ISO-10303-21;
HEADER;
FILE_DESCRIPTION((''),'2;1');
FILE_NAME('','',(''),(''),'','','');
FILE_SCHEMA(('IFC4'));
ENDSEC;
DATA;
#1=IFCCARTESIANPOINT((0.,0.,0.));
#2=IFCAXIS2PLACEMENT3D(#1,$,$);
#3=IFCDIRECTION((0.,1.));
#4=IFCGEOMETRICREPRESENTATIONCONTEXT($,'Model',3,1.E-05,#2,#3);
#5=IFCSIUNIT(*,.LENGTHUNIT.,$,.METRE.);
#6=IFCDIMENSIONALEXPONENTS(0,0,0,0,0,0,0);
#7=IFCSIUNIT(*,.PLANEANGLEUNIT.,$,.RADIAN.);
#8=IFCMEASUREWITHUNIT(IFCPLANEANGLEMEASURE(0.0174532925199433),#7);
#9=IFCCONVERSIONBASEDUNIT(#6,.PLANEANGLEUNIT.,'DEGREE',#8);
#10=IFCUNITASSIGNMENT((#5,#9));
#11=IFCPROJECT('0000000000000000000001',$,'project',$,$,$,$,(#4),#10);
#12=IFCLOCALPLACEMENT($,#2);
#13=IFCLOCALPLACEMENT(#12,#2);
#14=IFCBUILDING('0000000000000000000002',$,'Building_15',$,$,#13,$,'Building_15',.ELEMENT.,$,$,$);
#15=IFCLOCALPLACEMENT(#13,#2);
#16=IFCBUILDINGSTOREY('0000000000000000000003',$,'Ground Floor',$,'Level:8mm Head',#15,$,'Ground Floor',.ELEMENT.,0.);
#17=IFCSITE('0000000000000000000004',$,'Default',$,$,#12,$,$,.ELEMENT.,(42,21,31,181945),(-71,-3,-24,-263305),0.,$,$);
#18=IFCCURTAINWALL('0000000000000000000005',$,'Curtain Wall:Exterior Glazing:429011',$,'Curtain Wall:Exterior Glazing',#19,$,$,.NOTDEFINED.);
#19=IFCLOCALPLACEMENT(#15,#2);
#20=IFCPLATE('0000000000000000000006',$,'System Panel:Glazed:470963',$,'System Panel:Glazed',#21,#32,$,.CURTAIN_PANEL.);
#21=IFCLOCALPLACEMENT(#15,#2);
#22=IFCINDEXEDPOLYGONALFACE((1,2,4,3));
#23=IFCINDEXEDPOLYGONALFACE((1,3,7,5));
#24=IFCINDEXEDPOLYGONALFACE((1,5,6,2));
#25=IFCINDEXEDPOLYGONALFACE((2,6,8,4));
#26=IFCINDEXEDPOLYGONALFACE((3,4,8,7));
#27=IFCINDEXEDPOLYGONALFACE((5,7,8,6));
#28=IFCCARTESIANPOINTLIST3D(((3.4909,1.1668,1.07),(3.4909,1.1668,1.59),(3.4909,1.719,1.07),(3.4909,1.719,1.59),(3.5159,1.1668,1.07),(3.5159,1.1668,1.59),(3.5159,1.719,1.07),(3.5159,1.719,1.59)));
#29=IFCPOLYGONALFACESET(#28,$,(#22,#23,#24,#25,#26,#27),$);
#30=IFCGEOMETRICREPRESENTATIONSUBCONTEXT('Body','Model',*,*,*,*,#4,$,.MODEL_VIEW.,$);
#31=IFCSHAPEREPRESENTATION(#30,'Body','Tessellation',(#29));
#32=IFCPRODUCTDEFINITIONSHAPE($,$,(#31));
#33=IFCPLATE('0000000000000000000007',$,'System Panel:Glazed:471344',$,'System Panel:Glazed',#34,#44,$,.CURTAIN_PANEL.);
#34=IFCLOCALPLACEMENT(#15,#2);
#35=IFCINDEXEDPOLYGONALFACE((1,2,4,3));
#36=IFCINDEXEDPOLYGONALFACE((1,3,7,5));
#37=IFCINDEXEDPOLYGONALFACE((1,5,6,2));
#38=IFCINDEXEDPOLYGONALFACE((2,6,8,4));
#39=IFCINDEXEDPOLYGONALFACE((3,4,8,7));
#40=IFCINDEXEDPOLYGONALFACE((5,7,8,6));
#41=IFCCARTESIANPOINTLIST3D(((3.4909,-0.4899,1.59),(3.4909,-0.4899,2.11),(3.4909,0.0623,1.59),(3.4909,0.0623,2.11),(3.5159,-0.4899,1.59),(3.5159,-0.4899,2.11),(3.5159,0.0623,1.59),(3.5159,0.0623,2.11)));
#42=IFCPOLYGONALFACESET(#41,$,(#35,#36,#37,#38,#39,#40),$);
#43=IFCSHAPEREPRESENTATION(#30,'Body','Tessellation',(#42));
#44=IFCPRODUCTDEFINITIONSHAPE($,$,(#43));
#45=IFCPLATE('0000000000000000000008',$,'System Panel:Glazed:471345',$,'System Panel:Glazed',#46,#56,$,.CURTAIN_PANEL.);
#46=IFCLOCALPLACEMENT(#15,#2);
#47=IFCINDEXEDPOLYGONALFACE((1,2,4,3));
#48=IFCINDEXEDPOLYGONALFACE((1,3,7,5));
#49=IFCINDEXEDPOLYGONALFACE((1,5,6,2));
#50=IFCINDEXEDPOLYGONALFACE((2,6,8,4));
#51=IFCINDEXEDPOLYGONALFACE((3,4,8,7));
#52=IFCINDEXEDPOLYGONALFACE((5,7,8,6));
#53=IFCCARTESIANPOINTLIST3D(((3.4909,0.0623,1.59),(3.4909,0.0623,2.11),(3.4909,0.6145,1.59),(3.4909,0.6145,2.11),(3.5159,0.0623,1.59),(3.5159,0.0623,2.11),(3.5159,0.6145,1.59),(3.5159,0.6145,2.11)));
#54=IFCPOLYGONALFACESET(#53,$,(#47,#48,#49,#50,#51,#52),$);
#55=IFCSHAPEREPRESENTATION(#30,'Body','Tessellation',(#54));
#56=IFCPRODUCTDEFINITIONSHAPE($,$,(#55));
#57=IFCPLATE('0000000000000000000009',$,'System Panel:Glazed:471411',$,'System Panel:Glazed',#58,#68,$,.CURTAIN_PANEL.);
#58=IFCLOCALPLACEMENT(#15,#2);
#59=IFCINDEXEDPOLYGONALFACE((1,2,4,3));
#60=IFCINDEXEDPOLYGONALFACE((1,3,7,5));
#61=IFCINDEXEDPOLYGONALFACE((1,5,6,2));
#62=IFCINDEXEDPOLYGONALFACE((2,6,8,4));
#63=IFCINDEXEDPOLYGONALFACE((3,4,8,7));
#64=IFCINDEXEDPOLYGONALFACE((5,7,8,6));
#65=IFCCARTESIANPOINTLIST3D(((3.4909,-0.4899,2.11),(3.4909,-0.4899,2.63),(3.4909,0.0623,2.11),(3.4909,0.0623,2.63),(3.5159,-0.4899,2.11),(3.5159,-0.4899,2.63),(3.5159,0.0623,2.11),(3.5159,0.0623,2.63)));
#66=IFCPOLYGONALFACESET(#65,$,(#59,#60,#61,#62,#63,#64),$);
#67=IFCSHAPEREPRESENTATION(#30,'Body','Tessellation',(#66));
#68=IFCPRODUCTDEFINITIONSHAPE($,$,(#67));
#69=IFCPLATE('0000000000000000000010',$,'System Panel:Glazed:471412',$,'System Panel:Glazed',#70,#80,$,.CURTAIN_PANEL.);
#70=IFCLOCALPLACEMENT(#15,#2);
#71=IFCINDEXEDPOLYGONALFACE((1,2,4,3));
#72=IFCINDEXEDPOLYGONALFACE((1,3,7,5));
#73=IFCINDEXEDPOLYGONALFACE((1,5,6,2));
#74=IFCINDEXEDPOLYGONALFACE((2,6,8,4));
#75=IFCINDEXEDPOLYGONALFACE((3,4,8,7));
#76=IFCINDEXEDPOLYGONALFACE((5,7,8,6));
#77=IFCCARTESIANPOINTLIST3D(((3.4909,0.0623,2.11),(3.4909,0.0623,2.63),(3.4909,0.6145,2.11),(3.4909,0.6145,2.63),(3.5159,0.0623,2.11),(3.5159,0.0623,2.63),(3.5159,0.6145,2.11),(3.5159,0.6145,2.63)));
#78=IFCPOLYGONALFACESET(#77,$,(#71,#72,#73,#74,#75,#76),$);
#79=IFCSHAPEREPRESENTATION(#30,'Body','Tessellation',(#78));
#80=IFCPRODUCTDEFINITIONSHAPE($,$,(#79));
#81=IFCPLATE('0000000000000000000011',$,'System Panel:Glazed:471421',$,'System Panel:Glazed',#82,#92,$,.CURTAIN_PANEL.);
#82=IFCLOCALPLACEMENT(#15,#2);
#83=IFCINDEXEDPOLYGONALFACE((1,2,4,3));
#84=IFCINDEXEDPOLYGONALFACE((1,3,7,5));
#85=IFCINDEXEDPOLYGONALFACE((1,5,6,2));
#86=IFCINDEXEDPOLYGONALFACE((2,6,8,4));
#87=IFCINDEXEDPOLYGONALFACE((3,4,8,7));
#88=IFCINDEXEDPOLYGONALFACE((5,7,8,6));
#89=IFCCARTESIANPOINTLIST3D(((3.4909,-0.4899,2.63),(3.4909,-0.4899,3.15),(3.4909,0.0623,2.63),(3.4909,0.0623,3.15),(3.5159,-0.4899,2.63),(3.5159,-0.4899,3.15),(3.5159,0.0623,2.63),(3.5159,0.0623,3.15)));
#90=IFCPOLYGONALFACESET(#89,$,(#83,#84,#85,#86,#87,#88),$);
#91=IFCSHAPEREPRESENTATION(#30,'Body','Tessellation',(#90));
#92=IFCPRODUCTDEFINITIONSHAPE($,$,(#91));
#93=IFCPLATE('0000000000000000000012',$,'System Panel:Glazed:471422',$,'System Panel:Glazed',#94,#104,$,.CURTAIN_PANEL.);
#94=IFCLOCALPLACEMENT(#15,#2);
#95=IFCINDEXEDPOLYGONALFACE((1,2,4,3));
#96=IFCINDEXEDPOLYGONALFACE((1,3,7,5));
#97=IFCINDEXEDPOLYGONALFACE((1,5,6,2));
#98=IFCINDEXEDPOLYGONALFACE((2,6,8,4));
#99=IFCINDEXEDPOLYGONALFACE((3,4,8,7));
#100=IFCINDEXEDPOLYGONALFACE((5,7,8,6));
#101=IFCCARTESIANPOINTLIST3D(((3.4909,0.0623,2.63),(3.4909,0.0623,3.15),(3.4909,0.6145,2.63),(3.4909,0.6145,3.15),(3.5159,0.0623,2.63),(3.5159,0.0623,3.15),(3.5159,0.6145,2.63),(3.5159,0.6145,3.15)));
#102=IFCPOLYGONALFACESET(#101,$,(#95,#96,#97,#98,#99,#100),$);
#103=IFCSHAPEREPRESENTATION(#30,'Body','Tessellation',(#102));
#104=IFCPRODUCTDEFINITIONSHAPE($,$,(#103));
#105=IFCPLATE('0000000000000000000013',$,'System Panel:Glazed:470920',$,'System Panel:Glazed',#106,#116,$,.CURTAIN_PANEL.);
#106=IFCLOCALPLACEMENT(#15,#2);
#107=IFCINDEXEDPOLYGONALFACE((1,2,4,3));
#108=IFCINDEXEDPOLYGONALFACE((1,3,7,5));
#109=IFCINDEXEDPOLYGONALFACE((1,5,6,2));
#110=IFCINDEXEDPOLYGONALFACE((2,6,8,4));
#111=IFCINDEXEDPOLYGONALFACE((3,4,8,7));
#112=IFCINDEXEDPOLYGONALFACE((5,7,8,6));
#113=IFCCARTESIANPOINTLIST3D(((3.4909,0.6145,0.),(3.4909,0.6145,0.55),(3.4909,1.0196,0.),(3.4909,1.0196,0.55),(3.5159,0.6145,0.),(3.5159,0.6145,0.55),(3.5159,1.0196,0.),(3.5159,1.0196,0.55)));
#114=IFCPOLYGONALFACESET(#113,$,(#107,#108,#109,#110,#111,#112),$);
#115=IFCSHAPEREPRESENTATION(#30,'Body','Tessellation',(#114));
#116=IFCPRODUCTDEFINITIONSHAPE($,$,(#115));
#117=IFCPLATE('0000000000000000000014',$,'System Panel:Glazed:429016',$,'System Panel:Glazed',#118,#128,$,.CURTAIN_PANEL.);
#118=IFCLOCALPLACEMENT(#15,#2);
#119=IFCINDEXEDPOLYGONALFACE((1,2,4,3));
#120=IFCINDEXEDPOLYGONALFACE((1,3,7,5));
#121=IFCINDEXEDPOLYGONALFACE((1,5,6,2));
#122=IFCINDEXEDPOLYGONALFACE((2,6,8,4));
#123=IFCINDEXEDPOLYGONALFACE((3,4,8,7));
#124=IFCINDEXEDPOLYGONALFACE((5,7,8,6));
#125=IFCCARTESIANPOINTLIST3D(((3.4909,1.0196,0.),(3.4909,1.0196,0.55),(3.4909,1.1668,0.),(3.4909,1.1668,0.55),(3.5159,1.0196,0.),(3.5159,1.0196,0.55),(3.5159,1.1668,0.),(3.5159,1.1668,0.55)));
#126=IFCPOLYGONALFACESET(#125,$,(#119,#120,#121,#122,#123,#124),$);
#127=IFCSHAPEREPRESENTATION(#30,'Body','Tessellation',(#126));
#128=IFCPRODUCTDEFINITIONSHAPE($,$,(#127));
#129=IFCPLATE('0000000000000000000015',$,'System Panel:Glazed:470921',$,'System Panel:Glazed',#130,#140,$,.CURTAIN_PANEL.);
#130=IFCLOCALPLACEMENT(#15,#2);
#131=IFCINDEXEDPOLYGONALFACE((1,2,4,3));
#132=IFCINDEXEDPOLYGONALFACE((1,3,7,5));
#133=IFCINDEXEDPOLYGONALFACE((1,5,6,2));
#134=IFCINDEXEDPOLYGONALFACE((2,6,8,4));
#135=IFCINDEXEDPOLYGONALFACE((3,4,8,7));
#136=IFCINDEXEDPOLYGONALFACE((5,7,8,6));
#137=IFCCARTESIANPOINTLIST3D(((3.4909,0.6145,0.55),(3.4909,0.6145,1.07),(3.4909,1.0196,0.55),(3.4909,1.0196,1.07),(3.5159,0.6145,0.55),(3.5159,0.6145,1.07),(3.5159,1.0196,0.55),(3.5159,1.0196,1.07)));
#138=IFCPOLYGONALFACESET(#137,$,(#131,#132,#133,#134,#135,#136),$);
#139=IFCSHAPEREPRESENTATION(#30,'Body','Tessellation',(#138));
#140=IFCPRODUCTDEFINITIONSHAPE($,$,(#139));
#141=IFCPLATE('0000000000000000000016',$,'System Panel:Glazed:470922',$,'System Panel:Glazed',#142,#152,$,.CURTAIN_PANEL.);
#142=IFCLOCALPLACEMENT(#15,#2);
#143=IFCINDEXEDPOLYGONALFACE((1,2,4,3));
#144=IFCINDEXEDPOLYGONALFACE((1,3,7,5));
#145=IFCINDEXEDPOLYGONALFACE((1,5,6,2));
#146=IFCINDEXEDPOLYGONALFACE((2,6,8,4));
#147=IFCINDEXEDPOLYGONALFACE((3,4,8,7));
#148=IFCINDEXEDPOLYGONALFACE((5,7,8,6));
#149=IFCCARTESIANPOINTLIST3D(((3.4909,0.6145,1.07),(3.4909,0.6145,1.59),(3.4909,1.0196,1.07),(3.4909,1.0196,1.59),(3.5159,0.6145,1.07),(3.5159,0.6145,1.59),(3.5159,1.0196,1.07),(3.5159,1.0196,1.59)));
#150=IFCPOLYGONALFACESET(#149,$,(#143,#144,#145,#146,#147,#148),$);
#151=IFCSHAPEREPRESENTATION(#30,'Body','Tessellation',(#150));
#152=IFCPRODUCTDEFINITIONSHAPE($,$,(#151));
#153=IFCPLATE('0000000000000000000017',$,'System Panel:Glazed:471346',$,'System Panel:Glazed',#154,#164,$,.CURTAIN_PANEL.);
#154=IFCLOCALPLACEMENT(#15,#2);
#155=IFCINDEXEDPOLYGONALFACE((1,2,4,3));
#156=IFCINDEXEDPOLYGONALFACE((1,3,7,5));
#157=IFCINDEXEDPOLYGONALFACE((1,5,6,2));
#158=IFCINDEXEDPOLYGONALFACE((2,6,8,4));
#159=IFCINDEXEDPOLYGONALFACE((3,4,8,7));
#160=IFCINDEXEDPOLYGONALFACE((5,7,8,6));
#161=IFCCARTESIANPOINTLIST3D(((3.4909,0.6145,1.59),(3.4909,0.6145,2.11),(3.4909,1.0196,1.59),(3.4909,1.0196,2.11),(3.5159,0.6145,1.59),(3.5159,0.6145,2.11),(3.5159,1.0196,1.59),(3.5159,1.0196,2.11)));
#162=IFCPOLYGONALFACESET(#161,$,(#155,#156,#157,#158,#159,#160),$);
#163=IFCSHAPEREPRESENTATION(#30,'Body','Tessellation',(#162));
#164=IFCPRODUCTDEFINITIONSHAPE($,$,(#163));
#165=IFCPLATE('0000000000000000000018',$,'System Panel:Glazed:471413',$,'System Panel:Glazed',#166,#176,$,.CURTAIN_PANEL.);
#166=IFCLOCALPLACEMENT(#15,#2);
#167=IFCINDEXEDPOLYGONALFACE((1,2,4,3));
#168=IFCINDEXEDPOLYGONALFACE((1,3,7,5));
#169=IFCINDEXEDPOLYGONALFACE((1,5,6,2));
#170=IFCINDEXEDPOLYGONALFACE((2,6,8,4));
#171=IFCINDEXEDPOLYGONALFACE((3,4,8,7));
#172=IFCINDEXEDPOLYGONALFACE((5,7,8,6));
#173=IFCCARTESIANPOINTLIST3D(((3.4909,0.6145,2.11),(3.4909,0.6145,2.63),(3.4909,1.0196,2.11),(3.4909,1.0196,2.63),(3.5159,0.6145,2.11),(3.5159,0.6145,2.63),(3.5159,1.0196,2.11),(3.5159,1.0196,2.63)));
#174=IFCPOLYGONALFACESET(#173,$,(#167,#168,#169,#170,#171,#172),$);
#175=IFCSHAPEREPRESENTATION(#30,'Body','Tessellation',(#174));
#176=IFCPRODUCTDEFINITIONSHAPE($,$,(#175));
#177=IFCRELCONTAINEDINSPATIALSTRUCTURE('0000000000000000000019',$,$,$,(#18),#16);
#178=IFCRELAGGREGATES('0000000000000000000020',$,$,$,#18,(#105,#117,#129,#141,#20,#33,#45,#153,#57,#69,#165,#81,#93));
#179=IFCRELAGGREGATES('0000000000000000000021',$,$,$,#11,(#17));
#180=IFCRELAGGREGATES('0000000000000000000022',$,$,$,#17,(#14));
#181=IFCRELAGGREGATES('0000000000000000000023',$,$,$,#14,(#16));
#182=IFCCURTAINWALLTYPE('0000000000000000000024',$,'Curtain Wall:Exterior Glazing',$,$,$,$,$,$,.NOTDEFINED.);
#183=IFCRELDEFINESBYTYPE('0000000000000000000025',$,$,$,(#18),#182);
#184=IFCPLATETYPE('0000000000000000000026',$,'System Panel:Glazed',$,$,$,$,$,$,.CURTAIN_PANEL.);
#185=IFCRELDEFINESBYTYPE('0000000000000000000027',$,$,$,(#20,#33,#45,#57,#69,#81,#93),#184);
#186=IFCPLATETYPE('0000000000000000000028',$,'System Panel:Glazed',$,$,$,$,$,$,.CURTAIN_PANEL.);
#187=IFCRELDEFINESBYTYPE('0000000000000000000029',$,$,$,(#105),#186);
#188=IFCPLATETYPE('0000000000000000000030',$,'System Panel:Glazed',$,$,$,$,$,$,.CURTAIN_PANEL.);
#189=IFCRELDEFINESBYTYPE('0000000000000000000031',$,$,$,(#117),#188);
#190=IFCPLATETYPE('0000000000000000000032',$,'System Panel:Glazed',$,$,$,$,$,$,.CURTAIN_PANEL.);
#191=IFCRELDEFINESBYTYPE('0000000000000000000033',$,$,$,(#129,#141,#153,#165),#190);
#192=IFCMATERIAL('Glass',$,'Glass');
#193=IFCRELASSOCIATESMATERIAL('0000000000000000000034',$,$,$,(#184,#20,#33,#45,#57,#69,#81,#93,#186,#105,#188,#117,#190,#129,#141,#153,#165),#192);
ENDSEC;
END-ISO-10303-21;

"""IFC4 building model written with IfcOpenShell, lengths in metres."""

from ifc_helpers import new_model, entity, si_unit, converted_unit, direction, frame, origin, place, context, subcontext, project, spatial, indexed_curve, outline, extrude, source, transform, mapped, material, type_object, type_shapes, element, aggregate, save


model = new_model("IFC4")

# Units and contexts
model_context = context("Model", 3, precision=1e-05, world=origin(), true_north=direction((0.0, 1.0)))
body_context = subcontext(model_context, "Body", "Model", "MODEL_VIEW")
ifc_project = project(units=[si_unit("LENGTHUNIT", "METRE"), converted_unit("PLANEANGLEUNIT", "DEGREE", entity("IfcPlaneAngleMeasure", 0.0174532925199433), si_unit("PLANEANGLEUNIT", "RADIAN"), dimensions=[0, 0, 0, 0, 0, 0, 0])], contexts=[model_context])

# Site, building, storey
site_placement = place(None, origin())
site = spatial("IfcSite", under=ifc_project, at=site_placement, Name="Default", CompositionType="ELEMENT", RefLatitude=(42, 21, 31, 181945), RefLongitude=(-71, -3, -24, -263305), RefElevation=0.0)
building_placement = place(site_placement, origin())
building = spatial("IfcBuilding", under=site, at=building_placement, Name="Building_15", LongName="Building_15", CompositionType="ELEMENT")
storey_placement = place(building_placement, origin())
storey = spatial("IfcBuildingStorey", under=building, at=storey_placement, Name="Ground Floor", ObjectType="Level:8mm Head", LongName="Ground Floor", CompositionType="ELEMENT", Elevation=0.0)

# Curtain wall, plates
curtain_wall_type = type_object("IfcCurtainWallType", Name="Curtain Wall:Exterior Glazing", PredefinedType="NOTDEFINED")
curtain_wall_placement = place(storey_placement, origin())
curtain_wall = element("IfcCurtainWall", 1, at=curtain_wall_placement, inside=storey, type_object=curtain_wall_type, Name="Curtain Wall:Exterior Glazing:429011", ObjectType="Curtain Wall:Exterior Glazing", PredefinedType="NOTDEFINED")
ifc_material_1 = material(Name="Glass", Category="Glass")
plate_type_1 = type_object("IfcPlateType", Name="System Panel:Glazed", PredefinedType="CURTAIN_PANEL", material=ifc_material_1)
shared_shape_1 = source(origin(), body_context, "Body", "SweptSolid", [
    extrude(outline(indexed_curve([(-0.0125, -0.2761), (0.0125, -0.2761), (0.0125, 0.2761), (-0.0125, 0.2761), (-0.0125, -0.2761)], self_intersect=False)), frame((0.0, 0.037, 0.0), z_axis=(0.0, 0.0, 1.0), x_axis=(0.0, 1.0, 0.0)), (0.0, 0.0, 1.0), 0.52),
])
type_shapes(plate_type_1, [shared_shape_1])
plate_1_placement = place(curtain_wall_placement, frame((3.5404, 1.4429, 1.07), z_axis=(0.0, 0.0, 1.0), x_axis=(0.0, 1.0, 0.0)))
plate_1 = element("IfcPlate", 2, at=plate_1_placement, type_object=plate_type_1, material=ifc_material_1, Name="System Panel:Glazed:470963", ObjectType="System Panel:Glazed", PredefinedType="CURTAIN_PANEL", context=body_context, shape_type="MappedRepresentation", body=[
    mapped(shared_shape_1, transform((0.0, 0.0, 0.0), scale=1.0)),
])
plate_2_placement = place(curtain_wall_placement, frame((3.5404, -0.2138, 1.59), z_axis=(0.0, 0.0, 1.0), x_axis=(0.0, 1.0, 0.0)))
plate_2 = element("IfcPlate", 3, at=plate_2_placement, type_object=plate_type_1, material=ifc_material_1, Name="System Panel:Glazed:471344", ObjectType="System Panel:Glazed", PredefinedType="CURTAIN_PANEL", context=body_context, shape_type="MappedRepresentation", body=[
    mapped(shared_shape_1, transform((0.0, 0.0, 0.0), scale=1.0)),
])
plate_3_placement = place(curtain_wall_placement, frame((3.5404, 0.3384, 1.59), z_axis=(0.0, 0.0, 1.0), x_axis=(0.0, 1.0, 0.0)))
plate_3 = element("IfcPlate", 4, at=plate_3_placement, type_object=plate_type_1, material=ifc_material_1, Name="System Panel:Glazed:471345", ObjectType="System Panel:Glazed", PredefinedType="CURTAIN_PANEL", context=body_context, shape_type="MappedRepresentation", body=[
    mapped(shared_shape_1, transform((0.0, 0.0, 0.0), scale=1.0)),
])
plate_4_placement = place(curtain_wall_placement, frame((3.5404, -0.2138, 2.11), z_axis=(0.0, 0.0, 1.0), x_axis=(0.0, 1.0, 0.0)))
plate_4 = element("IfcPlate", 5, at=plate_4_placement, type_object=plate_type_1, material=ifc_material_1, Name="System Panel:Glazed:471411", ObjectType="System Panel:Glazed", PredefinedType="CURTAIN_PANEL", context=body_context, shape_type="MappedRepresentation", body=[
    mapped(shared_shape_1, transform((0.0, 0.0, 0.0), scale=1.0)),
])
plate_5_placement = place(curtain_wall_placement, frame((3.5404, 0.3384, 2.11), z_axis=(0.0, 0.0, 1.0), x_axis=(0.0, 1.0, 0.0)))
plate_5 = element("IfcPlate", 6, at=plate_5_placement, type_object=plate_type_1, material=ifc_material_1, Name="System Panel:Glazed:471412", ObjectType="System Panel:Glazed", PredefinedType="CURTAIN_PANEL", context=body_context, shape_type="MappedRepresentation", body=[
    mapped(shared_shape_1, transform((0.0, 0.0, 0.0), scale=1.0)),
])
plate_6_placement = place(curtain_wall_placement, frame((3.5404, -0.2138, 2.63), z_axis=(0.0, 0.0, 1.0), x_axis=(0.0, 1.0, 0.0)))
plate_6 = element("IfcPlate", 7, at=plate_6_placement, type_object=plate_type_1, material=ifc_material_1, Name="System Panel:Glazed:471421", ObjectType="System Panel:Glazed", PredefinedType="CURTAIN_PANEL", context=body_context, shape_type="MappedRepresentation", body=[
    mapped(shared_shape_1, transform((0.0, 0.0, 0.0), scale=1.0)),
])
plate_7_placement = place(curtain_wall_placement, frame((3.5404, 0.3384, 2.63), z_axis=(0.0, 0.0, 1.0), x_axis=(0.0, 1.0, 0.0)))
plate_7 = element("IfcPlate", 8, at=plate_7_placement, type_object=plate_type_1, material=ifc_material_1, Name="System Panel:Glazed:471422", ObjectType="System Panel:Glazed", PredefinedType="CURTAIN_PANEL", context=body_context, shape_type="MappedRepresentation", body=[
    mapped(shared_shape_1, transform((0.0, 0.0, 0.0), scale=1.0)),
])
plate_type_2 = type_object("IfcPlateType", Name="System Panel:Glazed", PredefinedType="CURTAIN_PANEL", material=ifc_material_1)
shared_shape_2 = source(origin(), body_context, "Body", "SweptSolid", [
    extrude(outline(indexed_curve([(-0.0125, -0.2025), (0.0125, -0.2025), (0.0125, 0.2025), (-0.0125, 0.2025), (-0.0125, -0.2025)], self_intersect=False)), frame((0.0, 0.037, 0.0), z_axis=(0.0, 0.0, 1.0), x_axis=(0.0, 1.0, 0.0)), (0.0, 0.0, 1.0), 0.55),
])
type_shapes(plate_type_2, [shared_shape_2])
plate_8_placement = place(curtain_wall_placement, frame((3.5404, 0.8171, 0.0), z_axis=(0.0, 0.0, 1.0), x_axis=(0.0, 1.0, 0.0)))
plate_8 = element("IfcPlate", 9, at=plate_8_placement, type_object=plate_type_2, material=ifc_material_1, Name="System Panel:Glazed:470920", ObjectType="System Panel:Glazed", PredefinedType="CURTAIN_PANEL", context=body_context, shape_type="MappedRepresentation", body=[
    mapped(shared_shape_2, transform((0.0, 0.0, 0.0), scale=1.0)),
])
plate_type_3 = type_object("IfcPlateType", Name="System Panel:Glazed", PredefinedType="CURTAIN_PANEL", material=ifc_material_1)
shared_shape_3 = source(origin(), body_context, "Body", "SweptSolid", [
    extrude(outline(indexed_curve([(-0.0125, -0.0736), (0.0125, -0.0736), (0.0125, 0.0736), (-0.0125, 0.0736), (-0.0125, -0.0736)], self_intersect=False)), frame((0.0, 0.037, 0.0), z_axis=(0.0, 0.0, 1.0), x_axis=(0.0, 1.0, 0.0)), (0.0, 0.0, 1.0), 0.55),
])
type_shapes(plate_type_3, [shared_shape_3])
plate_9_placement = place(curtain_wall_placement, frame((3.5404, 1.0932, 0.0), z_axis=(0.0, 0.0, 1.0), x_axis=(0.0, 1.0, 0.0)))
plate_9 = element("IfcPlate", 10, at=plate_9_placement, type_object=plate_type_3, material=ifc_material_1, Name="System Panel:Glazed:429016", ObjectType="System Panel:Glazed", PredefinedType="CURTAIN_PANEL", context=body_context, shape_type="MappedRepresentation", body=[
    mapped(shared_shape_3, transform((0.0, 0.0, 0.0), scale=1.0)),
])
plate_type_4 = type_object("IfcPlateType", Name="System Panel:Glazed", PredefinedType="CURTAIN_PANEL", material=ifc_material_1)
shared_shape_4 = source(origin(), body_context, "Body", "SweptSolid", [
    extrude(outline(indexed_curve([(-0.0125, -0.2025), (0.0125, -0.2025), (0.0125, 0.2025), (-0.0125, 0.2025), (-0.0125, -0.2025)], self_intersect=False)), frame((0.0, 0.037, 0.0), z_axis=(0.0, 0.0, 1.0), x_axis=(0.0, 1.0, 0.0)), (0.0, 0.0, 1.0), 0.52),
])
type_shapes(plate_type_4, [shared_shape_4])
plate_10_placement = place(curtain_wall_placement, frame((3.5404, 0.8171, 0.55), z_axis=(0.0, 0.0, 1.0), x_axis=(0.0, 1.0, 0.0)))
plate_10 = element("IfcPlate", 11, at=plate_10_placement, type_object=plate_type_4, material=ifc_material_1, Name="System Panel:Glazed:470921", ObjectType="System Panel:Glazed", PredefinedType="CURTAIN_PANEL", context=body_context, shape_type="MappedRepresentation", body=[
    mapped(shared_shape_4, transform((0.0, 0.0, 0.0), scale=1.0)),
])
plate_11_placement = place(curtain_wall_placement, frame((3.5404, 0.8171, 1.07), z_axis=(0.0, 0.0, 1.0), x_axis=(0.0, 1.0, 0.0)))
plate_11 = element("IfcPlate", 12, at=plate_11_placement, type_object=plate_type_4, material=ifc_material_1, Name="System Panel:Glazed:470922", ObjectType="System Panel:Glazed", PredefinedType="CURTAIN_PANEL", context=body_context, shape_type="MappedRepresentation", body=[
    mapped(shared_shape_4, transform((0.0, 0.0, 0.0), scale=1.0)),
])
plate_12_placement = place(curtain_wall_placement, frame((3.5404, 0.8171, 1.59), z_axis=(0.0, 0.0, 1.0), x_axis=(0.0, 1.0, 0.0)))
plate_12 = element("IfcPlate", 13, at=plate_12_placement, type_object=plate_type_4, material=ifc_material_1, Name="System Panel:Glazed:471346", ObjectType="System Panel:Glazed", PredefinedType="CURTAIN_PANEL", context=body_context, shape_type="MappedRepresentation", body=[
    mapped(shared_shape_4, transform((0.0, 0.0, 0.0), scale=1.0)),
])
plate_13_placement = place(curtain_wall_placement, frame((3.5404, 0.8171, 2.11), z_axis=(0.0, 0.0, 1.0), x_axis=(0.0, 1.0, 0.0)))
plate_13 = element("IfcPlate", 14, at=plate_13_placement, type_object=plate_type_4, material=ifc_material_1, Name="System Panel:Glazed:471413", ObjectType="System Panel:Glazed", PredefinedType="CURTAIN_PANEL", context=body_context, shape_type="MappedRepresentation", body=[
    mapped(shared_shape_4, transform((0.0, 0.0, 0.0), scale=1.0)),
])
aggregate(curtain_wall, [plate_8, plate_9, plate_10, plate_11, plate_1, plate_2, plate_3, plate_12, plate_4, plate_5, plate_13, plate_6, plate_7])

save(model, "model.ifc")
